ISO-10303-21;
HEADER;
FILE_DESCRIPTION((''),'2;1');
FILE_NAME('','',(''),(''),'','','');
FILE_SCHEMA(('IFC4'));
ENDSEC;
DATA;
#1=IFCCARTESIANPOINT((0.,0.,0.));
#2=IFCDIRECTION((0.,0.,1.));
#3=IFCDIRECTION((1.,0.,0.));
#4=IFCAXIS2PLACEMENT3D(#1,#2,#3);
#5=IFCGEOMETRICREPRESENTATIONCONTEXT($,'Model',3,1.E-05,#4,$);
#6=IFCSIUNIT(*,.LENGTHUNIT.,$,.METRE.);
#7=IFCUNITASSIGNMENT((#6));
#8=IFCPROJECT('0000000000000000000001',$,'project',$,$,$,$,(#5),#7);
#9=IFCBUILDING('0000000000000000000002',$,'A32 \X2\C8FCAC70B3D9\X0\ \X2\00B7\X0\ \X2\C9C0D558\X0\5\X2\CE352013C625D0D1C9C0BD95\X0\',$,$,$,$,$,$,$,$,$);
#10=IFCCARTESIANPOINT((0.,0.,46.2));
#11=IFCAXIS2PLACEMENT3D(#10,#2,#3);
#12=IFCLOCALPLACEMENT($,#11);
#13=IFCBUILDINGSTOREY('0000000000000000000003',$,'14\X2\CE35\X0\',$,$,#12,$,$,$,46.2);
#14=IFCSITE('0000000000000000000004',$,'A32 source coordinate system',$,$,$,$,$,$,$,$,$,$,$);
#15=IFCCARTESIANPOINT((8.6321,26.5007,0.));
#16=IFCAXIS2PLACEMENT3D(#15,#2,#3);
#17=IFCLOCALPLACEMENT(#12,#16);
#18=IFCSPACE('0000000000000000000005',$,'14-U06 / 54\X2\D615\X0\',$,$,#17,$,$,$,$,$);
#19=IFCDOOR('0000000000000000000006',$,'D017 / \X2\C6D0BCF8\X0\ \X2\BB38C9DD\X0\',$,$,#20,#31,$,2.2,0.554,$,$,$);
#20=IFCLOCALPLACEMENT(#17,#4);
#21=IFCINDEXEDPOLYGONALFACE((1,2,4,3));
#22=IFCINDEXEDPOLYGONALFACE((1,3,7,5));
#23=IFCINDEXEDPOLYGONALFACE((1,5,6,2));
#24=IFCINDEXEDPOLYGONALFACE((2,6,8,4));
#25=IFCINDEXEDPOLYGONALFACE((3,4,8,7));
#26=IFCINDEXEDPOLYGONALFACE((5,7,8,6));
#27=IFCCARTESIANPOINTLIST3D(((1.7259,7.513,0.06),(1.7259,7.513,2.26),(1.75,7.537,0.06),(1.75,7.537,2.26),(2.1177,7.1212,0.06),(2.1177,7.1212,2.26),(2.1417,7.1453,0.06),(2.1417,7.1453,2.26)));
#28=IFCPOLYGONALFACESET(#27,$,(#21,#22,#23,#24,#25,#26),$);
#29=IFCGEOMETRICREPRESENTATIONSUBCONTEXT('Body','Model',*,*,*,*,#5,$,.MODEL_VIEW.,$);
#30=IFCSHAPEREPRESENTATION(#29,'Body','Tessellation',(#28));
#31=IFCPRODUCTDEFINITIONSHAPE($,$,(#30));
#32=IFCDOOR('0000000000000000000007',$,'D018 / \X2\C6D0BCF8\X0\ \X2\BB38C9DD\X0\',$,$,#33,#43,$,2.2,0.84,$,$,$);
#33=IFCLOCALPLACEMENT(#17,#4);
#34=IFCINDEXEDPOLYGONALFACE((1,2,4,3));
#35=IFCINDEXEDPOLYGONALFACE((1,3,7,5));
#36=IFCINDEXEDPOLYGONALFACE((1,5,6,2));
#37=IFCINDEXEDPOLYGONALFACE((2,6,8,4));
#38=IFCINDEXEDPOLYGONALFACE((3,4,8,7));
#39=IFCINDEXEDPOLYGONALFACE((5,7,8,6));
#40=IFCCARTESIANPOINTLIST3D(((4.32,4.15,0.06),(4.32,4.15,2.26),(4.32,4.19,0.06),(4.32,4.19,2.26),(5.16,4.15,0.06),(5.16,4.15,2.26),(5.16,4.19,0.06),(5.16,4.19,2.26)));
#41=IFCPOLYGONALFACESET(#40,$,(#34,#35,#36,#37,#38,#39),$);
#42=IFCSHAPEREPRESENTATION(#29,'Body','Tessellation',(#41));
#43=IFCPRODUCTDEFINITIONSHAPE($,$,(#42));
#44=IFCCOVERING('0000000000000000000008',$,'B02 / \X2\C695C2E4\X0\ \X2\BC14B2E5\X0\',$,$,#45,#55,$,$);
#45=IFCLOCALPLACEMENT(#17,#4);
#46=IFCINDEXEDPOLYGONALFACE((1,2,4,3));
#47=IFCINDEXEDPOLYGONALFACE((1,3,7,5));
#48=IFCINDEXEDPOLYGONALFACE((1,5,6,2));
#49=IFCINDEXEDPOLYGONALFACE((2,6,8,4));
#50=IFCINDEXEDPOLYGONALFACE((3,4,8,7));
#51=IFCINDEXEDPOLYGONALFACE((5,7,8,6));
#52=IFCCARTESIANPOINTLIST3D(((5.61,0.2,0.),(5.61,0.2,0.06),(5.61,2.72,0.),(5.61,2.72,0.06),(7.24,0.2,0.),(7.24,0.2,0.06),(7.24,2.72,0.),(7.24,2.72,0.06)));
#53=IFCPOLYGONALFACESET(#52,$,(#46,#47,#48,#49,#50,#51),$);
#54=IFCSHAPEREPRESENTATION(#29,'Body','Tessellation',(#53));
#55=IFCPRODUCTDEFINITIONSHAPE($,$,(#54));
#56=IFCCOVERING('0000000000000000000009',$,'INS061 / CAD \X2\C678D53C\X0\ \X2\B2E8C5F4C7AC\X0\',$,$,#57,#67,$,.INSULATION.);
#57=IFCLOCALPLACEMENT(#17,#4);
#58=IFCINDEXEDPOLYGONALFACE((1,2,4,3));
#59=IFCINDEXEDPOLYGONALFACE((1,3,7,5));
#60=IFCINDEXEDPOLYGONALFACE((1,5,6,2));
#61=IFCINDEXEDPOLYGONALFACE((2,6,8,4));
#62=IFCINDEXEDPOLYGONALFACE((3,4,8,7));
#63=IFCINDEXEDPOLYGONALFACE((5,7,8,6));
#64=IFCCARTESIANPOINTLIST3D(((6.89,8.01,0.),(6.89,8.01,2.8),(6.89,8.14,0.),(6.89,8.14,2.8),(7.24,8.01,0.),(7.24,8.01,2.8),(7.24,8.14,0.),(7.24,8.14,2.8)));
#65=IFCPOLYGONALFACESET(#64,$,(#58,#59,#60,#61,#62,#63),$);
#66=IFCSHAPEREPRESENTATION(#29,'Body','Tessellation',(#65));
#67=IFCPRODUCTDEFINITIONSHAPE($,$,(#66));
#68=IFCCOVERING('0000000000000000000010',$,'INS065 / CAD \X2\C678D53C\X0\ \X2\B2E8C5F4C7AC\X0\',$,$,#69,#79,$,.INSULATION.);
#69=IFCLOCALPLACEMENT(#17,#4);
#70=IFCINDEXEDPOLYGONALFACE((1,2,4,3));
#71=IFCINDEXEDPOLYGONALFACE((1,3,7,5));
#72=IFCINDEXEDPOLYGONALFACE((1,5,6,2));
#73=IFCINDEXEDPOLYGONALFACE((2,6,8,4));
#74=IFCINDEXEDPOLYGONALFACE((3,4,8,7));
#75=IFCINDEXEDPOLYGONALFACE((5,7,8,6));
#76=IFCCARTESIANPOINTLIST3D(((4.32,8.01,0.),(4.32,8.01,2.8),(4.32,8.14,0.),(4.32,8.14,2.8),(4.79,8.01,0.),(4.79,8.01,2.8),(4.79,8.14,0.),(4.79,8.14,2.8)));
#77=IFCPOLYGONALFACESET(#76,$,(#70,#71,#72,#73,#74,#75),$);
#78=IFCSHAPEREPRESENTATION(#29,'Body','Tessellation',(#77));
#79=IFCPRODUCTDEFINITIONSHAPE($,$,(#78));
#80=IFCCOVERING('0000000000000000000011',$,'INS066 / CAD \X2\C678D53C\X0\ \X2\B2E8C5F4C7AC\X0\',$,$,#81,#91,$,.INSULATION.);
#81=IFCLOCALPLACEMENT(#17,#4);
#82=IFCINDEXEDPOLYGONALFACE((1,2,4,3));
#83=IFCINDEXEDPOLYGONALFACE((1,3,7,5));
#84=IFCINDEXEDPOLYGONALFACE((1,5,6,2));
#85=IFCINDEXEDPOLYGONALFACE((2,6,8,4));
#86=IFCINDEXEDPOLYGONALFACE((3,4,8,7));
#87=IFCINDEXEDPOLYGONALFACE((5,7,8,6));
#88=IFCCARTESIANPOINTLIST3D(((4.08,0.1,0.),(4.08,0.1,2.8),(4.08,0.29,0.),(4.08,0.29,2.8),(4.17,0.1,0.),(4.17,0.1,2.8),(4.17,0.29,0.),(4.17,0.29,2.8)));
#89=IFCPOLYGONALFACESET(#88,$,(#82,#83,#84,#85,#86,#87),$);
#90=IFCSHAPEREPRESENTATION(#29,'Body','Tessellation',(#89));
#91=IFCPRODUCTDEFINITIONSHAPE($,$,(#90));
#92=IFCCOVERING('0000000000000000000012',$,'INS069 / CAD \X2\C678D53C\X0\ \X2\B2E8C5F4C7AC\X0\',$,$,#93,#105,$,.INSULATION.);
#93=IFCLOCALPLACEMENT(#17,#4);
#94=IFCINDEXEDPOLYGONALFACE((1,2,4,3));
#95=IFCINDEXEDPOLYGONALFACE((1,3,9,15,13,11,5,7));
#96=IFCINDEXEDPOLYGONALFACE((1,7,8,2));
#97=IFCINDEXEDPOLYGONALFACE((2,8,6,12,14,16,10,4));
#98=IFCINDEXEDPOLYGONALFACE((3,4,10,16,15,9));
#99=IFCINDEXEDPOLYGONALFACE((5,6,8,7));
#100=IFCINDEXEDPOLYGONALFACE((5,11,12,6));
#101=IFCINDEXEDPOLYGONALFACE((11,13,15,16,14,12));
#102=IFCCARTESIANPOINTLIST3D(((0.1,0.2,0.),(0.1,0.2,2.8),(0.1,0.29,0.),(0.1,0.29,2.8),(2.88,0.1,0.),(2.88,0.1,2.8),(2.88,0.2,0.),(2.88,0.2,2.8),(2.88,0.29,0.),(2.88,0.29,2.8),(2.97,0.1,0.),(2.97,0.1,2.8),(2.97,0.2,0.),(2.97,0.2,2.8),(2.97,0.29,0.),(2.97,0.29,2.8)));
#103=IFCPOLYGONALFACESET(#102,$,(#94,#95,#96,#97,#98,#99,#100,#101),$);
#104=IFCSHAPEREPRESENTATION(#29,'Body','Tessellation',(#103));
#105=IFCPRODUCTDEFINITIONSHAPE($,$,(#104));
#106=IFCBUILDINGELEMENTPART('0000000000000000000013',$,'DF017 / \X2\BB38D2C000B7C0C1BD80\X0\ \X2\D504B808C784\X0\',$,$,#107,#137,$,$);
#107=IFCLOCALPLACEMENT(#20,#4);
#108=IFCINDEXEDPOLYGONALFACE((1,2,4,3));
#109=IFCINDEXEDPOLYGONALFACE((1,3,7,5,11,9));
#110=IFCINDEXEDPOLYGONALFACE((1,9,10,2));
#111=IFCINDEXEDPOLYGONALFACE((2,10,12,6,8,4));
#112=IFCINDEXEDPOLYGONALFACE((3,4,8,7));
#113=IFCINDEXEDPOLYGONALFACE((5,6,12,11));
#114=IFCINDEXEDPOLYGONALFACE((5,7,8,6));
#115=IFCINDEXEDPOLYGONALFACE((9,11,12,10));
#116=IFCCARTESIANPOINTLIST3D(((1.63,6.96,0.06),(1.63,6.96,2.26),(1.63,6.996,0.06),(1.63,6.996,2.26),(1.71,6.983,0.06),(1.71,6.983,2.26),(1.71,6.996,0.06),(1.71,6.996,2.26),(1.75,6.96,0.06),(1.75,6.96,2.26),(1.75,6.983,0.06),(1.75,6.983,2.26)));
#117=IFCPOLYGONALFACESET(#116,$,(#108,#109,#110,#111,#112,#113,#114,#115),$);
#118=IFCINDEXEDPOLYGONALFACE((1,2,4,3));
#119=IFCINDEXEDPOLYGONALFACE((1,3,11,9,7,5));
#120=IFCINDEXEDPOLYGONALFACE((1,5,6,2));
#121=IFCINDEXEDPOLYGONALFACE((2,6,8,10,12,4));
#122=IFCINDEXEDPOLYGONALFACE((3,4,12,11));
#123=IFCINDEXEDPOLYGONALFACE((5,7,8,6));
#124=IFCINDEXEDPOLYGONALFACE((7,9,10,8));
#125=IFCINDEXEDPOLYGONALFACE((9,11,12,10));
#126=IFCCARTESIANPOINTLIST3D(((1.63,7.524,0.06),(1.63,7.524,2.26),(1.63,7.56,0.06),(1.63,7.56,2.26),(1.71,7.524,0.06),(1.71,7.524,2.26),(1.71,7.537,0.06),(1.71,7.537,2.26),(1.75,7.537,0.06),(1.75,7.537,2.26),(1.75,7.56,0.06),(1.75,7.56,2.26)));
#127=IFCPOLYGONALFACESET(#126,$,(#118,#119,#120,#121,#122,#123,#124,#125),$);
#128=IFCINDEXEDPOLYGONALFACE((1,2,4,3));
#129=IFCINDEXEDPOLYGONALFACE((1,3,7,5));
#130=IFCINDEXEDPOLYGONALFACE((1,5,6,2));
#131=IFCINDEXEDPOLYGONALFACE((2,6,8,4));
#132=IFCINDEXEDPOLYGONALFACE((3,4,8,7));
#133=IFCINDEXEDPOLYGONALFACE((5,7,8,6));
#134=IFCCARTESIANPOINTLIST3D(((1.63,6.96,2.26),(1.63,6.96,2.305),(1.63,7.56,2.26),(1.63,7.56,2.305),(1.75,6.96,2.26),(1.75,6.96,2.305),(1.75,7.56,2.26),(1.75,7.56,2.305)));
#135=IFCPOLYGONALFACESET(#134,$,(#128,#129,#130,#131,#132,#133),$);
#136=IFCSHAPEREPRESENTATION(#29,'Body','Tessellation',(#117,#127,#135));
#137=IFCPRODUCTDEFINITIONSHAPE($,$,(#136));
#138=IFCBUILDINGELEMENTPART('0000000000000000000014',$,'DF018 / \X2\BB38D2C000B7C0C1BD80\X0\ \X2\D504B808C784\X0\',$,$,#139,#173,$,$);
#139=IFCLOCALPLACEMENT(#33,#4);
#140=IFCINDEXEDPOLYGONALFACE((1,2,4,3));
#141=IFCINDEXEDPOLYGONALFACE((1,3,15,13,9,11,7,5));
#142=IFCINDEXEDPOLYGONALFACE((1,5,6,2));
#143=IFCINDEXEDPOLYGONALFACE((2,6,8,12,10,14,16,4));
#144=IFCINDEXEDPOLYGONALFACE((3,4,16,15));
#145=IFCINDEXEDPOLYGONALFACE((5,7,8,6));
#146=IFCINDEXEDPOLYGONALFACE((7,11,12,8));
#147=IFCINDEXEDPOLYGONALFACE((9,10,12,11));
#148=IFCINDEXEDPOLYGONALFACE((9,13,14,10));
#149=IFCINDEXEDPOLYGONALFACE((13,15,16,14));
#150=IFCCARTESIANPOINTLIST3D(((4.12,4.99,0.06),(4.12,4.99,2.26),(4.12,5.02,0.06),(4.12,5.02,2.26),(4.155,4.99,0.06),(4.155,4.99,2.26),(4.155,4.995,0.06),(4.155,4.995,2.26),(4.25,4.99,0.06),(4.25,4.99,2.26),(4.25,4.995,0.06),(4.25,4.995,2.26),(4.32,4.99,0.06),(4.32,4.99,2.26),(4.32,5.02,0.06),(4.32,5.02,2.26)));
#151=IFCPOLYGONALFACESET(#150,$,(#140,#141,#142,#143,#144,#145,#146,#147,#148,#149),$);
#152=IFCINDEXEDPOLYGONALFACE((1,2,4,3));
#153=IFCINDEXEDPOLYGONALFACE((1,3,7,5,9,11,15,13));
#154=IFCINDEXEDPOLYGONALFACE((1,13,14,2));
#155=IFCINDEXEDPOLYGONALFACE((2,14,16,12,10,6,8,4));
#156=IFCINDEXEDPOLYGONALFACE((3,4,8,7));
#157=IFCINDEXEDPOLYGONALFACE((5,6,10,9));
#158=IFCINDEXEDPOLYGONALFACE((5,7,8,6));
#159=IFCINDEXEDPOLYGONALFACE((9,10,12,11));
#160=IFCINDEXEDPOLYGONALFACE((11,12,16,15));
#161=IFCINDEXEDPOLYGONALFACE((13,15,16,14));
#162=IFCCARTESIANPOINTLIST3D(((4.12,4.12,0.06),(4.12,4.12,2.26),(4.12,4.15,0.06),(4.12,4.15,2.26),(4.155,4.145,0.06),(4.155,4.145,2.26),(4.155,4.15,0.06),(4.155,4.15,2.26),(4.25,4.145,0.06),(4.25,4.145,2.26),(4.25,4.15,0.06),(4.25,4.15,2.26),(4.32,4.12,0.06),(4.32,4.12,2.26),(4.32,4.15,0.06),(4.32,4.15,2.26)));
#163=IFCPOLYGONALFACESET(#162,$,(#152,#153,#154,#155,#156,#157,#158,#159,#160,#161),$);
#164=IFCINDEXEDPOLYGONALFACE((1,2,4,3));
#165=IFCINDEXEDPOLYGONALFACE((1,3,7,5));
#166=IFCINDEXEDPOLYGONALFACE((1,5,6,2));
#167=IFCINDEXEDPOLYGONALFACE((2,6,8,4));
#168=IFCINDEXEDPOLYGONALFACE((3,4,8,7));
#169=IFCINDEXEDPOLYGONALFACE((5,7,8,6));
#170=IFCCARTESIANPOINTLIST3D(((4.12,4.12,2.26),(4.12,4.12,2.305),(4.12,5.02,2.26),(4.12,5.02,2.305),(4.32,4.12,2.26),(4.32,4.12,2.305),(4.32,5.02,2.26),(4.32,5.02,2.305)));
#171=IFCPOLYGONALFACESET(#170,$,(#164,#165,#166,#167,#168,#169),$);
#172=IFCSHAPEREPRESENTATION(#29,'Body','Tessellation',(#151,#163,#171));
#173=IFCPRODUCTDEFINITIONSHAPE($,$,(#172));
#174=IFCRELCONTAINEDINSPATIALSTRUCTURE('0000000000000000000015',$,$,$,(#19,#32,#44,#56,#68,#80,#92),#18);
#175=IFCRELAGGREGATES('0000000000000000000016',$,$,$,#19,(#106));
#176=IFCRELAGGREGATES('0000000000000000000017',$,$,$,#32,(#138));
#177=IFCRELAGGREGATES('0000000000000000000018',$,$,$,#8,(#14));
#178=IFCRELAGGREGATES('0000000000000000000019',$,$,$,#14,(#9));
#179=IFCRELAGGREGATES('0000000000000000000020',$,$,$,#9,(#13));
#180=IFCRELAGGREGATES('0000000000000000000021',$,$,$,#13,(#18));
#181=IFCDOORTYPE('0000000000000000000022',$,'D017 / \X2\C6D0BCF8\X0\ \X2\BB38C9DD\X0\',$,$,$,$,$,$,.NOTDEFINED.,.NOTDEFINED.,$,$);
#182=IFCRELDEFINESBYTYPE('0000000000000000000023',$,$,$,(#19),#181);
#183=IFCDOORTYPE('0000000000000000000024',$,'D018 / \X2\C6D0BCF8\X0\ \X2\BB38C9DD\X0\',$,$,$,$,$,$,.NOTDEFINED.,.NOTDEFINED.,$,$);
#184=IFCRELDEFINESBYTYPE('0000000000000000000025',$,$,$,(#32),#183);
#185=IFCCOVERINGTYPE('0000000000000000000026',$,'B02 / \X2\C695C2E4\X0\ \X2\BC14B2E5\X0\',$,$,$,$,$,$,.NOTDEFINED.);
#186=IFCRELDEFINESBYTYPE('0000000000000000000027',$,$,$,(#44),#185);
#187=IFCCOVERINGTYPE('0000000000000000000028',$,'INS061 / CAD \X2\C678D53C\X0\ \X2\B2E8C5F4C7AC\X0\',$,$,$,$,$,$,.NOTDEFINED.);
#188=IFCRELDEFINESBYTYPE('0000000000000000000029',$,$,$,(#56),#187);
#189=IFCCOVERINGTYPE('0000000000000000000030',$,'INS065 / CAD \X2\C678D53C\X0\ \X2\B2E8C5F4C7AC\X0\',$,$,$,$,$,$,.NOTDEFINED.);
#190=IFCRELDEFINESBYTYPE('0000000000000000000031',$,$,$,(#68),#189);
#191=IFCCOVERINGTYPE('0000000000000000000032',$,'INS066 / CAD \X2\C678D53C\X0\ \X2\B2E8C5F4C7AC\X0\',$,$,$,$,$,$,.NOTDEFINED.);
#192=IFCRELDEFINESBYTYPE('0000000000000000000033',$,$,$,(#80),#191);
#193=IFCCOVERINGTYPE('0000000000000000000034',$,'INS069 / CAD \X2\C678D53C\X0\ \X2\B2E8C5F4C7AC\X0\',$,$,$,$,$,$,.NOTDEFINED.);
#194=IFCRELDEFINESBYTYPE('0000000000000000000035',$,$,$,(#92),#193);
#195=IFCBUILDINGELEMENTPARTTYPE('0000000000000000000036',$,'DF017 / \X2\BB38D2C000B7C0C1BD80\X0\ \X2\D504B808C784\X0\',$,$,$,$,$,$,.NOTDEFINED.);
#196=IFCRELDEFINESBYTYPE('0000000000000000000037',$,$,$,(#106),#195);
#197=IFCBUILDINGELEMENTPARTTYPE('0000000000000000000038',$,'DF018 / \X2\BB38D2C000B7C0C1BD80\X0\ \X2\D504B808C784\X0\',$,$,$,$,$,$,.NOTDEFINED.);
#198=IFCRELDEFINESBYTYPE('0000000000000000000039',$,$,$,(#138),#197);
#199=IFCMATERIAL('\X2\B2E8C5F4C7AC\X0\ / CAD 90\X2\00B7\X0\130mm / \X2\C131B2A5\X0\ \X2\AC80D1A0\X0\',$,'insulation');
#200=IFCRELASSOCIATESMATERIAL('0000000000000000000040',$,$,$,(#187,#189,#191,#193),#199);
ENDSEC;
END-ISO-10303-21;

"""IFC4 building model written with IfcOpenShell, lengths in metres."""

from ifc_helpers import new_model, si_unit, frame, origin, origin_with_axes, place, context, subcontext, project, spatial, polyline, outline, extrude, source, transform, mapped, material, type_object, type_shapes, element, aggregate, save


model = new_model("IFC4")

# Units and contexts
model_context = context("Model", 3, precision=1e-05, world=origin_with_axes())
body_context = subcontext(model_context, "Body", "Model", "MODEL_VIEW")
ifc_project = project(units=[si_unit("LENGTHUNIT", "METRE")], contexts=[model_context])

# Site, building, storey, space
storey_placement = place(None, frame((0.0, 0.0, 46.2), z_axis=(0.0, 0.0, 1.0), x_axis=(1.0, 0.0, 0.0)))
space_1_placement = place(storey_placement, frame((8.6321, 26.5007, 0.0), z_axis=(0.0, 0.0, 1.0), x_axis=(1.0, 0.0, 0.0)))
site = spatial("IfcSite", under=ifc_project, Name="A32 source coordinate system")
building = spatial("IfcBuilding", under=site, Name="A32 주거동 · 지하5층–옥탑지붕")
storey = spatial("IfcBuildingStorey", under=building, at=storey_placement, Name="14층", Elevation=46.2)
space_1 = spatial("IfcSpace", under=storey, at=space_1_placement, Name="14-U06 / 54형")

# Doors
door_type_1 = type_object("IfcDoorType", Name="D017 / 원본 문짝", OperationType="NOTDEFINED", PredefinedType="NOTDEFINED")
shared_shape_1 = source(origin(), body_context, "Body", "SweptSolid", [
    extrude(outline(polyline([(1.75, 7.537), (2.1417, 7.1453), (2.1177, 7.1212), (1.7259, 7.513), (1.75, 7.537)])), frame((0.0, 0.0, 0.06)), (0.0, 0.0, 1.0), 2.2),
])
type_shapes(door_type_1, [shared_shape_1])
door_1_placement = place(space_1_placement, origin_with_axes())
door_1 = element("IfcDoor", 1, at=door_1_placement, inside=space_1, type_object=door_type_1, Name="D017 / 원본 문짝", OverallHeight=2.2, OverallWidth=0.554, context=body_context, shape_type="MappedRepresentation", body=[
    mapped(shared_shape_1, transform((0.0, 0.0, 0.0), scale=1.0)),
])
door_type_2 = type_object("IfcDoorType", Name="D018 / 원본 문짝", OperationType="NOTDEFINED", PredefinedType="NOTDEFINED")
shared_shape_2 = source(origin(), body_context, "Body", "SweptSolid", [
    extrude(outline(polyline([(5.16, 4.19), (5.16, 4.15), (4.32, 4.15), (4.32, 4.19), (5.16, 4.19)])), frame((0.0, 0.0, 0.06)), (0.0, 0.0, 1.0), 2.2),
])
type_shapes(door_type_2, [shared_shape_2])
door_2_placement = place(space_1_placement, origin_with_axes())
door_2 = element("IfcDoor", 2, at=door_2_placement, inside=space_1, type_object=door_type_2, Name="D018 / 원본 문짝", OverallHeight=2.2, OverallWidth=0.84, context=body_context, shape_type="MappedRepresentation", body=[
    mapped(shared_shape_2, transform((0.0, 0.0, 0.0), scale=1.0)),
])

# Coverings
covering_type_1 = type_object("IfcCoveringType", Name="B02 / 욕실 바닥", PredefinedType="NOTDEFINED")
shared_shape_3 = source(origin(), body_context, "Body", "SweptSolid", [
    extrude(outline(polyline([(5.61, 2.72), (7.24, 2.72), (7.24, 0.2), (5.61, 0.2), (5.61, 2.72)])), origin(), (0.0, 0.0, 1.0), 0.06),
])
type_shapes(covering_type_1, [shared_shape_3])
covering_1_placement = place(space_1_placement, origin_with_axes())
element("IfcCovering", 3, at=covering_1_placement, inside=space_1, type_object=covering_type_1, Name="B02 / 욕실 바닥", context=body_context, shape_type="MappedRepresentation", body=[
    mapped(shared_shape_3, transform((0.0, 0.0, 0.0), scale=1.0)),
])
ifc_material = material(Name="단열재 / CAD 90·130mm / 성능 검토", Category="insulation")
covering_type_2 = type_object("IfcCoveringType", Name="INS061 / CAD 외피 단열재", PredefinedType="NOTDEFINED", material=ifc_material)
shared_shape_4 = source(origin(), body_context, "Body", "SweptSolid", [
    extrude(outline(polyline([(6.89, 8.01), (6.89, 8.14), (7.24, 8.14), (7.24, 8.01), (6.89, 8.01)])), origin(), (0.0, 0.0, 1.0), 2.8),
])
type_shapes(covering_type_2, [shared_shape_4])
covering_2_placement = place(space_1_placement, origin_with_axes())
element("IfcCovering", 4, at=covering_2_placement, inside=space_1, type_object=covering_type_2, Name="INS061 / CAD 외피 단열재", PredefinedType="INSULATION", context=body_context, shape_type="MappedRepresentation", body=[
    mapped(shared_shape_4, transform((0.0, 0.0, 0.0), scale=1.0)),
])
covering_type_3 = type_object("IfcCoveringType", Name="INS065 / CAD 외피 단열재", PredefinedType="NOTDEFINED", material=ifc_material)
shared_shape_5 = source(origin(), body_context, "Body", "SweptSolid", [
    extrude(outline(polyline([(4.32, 8.01), (4.32, 8.14), (4.79, 8.14), (4.79, 8.01), (4.32, 8.01)])), origin(), (0.0, 0.0, 1.0), 2.8),
])
type_shapes(covering_type_3, [shared_shape_5])
covering_3_placement = place(space_1_placement, origin_with_axes())
element("IfcCovering", 5, at=covering_3_placement, inside=space_1, type_object=covering_type_3, Name="INS065 / CAD 외피 단열재", PredefinedType="INSULATION", context=body_context, shape_type="MappedRepresentation", body=[
    mapped(shared_shape_5, transform((0.0, 0.0, 0.0), scale=1.0)),
])
covering_type_4 = type_object("IfcCoveringType", Name="INS066 / CAD 외피 단열재", PredefinedType="NOTDEFINED", material=ifc_material)
shared_shape_6 = source(origin(), body_context, "Body", "SweptSolid", [
    extrude(outline(polyline([(4.08, 0.29), (4.17, 0.29), (4.17, 0.1), (4.08, 0.1), (4.08, 0.29)])), origin(), (0.0, 0.0, 1.0), 2.8),
])
type_shapes(covering_type_4, [shared_shape_6])
covering_4_placement = place(space_1_placement, origin_with_axes())
element("IfcCovering", 6, at=covering_4_placement, inside=space_1, type_object=covering_type_4, Name="INS066 / CAD 외피 단열재", PredefinedType="INSULATION", context=body_context, shape_type="MappedRepresentation", body=[
    mapped(shared_shape_6, transform((0.0, 0.0, 0.0), scale=1.0)),
])
covering_type_5 = type_object("IfcCoveringType", Name="INS069 / CAD 외피 단열재", PredefinedType="NOTDEFINED", material=ifc_material)
shared_shape_7 = source(origin(), body_context, "Body", "SweptSolid", [
    extrude(outline(polyline([(2.97, 0.1), (2.88, 0.1), (2.88, 0.2), (0.1, 0.2), (0.1, 0.29), (2.88, 0.29), (2.97, 0.29), (2.97, 0.2), (2.97, 0.1)])), origin(), (0.0, 0.0, 1.0), 2.8),
])
type_shapes(covering_type_5, [shared_shape_7])
covering_5_placement = place(space_1_placement, origin_with_axes())
element("IfcCovering", 7, at=covering_5_placement, inside=space_1, type_object=covering_type_5, Name="INS069 / CAD 외피 단열재", PredefinedType="INSULATION", context=body_context, shape_type="MappedRepresentation", body=[
    mapped(shared_shape_7, transform((0.0, 0.0, 0.0), scale=1.0)),
])

# Building element parts
building_element_part_type_1 = type_object("IfcBuildingElementPartType", Name="DF017 / 문틀·상부 프레임", PredefinedType="NOTDEFINED")
shared_shape_8 = source(origin(), body_context, "Body", "SweptSolid", [
    extrude(outline(polyline([(1.63, 6.996), (1.71, 6.996), (1.71, 6.983), (1.75, 6.983), (1.75, 6.96), (1.63, 6.96), (1.63, 6.996)])), frame((0.0, 0.0, 0.06)), (0.0, 0.0, 1.0), 2.2),
    extrude(outline(polyline([(1.75, 7.56), (1.75, 7.537), (1.71, 7.537), (1.71, 7.524), (1.63, 7.524), (1.63, 7.56), (1.75, 7.56)])), frame((0.0, 0.0, 0.06)), (0.0, 0.0, 1.0), 2.2),
    extrude(outline(polyline([(1.63, 6.96), (1.63, 7.56), (1.75, 7.56), (1.75, 6.96), (1.63, 6.96)])), frame((0.0, 0.0, 2.26)), (0.0, 0.0, 1.0), 0.045),
])
type_shapes(building_element_part_type_1, [shared_shape_8])
building_element_part_1_placement = place(door_1_placement, origin_with_axes())
building_element_part_1 = element("IfcBuildingElementPart", 8, at=building_element_part_1_placement, type_object=building_element_part_type_1, Name="DF017 / 문틀·상부 프레임", context=body_context, shape_type="MappedRepresentation", body=[
    mapped(shared_shape_8, transform((0.0, 0.0, 0.0), scale=1.0)),
])
aggregate(door_1, [building_element_part_1])
building_element_part_type_2 = type_object("IfcBuildingElementPartType", Name="DF018 / 문틀·상부 프레임", PredefinedType="NOTDEFINED")
shared_shape_9 = source(origin(), body_context, "Body", "SweptSolid", [
    extrude(outline(polyline([(4.32, 4.99), (4.25, 4.99), (4.25, 4.995), (4.155, 4.995), (4.155, 4.99), (4.12, 4.99), (4.12, 5.02), (4.32, 5.02), (4.32, 4.99)])), frame((0.0, 0.0, 0.06)), (0.0, 0.0, 1.0), 2.2),
    extrude(outline(polyline([(4.12, 4.12), (4.12, 4.15), (4.155, 4.15), (4.155, 4.145), (4.25, 4.145), (4.25, 4.15), (4.32, 4.15), (4.32, 4.12), (4.12, 4.12)])), frame((0.0, 0.0, 0.06)), (0.0, 0.0, 1.0), 2.2),
    extrude(outline(polyline([(4.12, 4.12), (4.12, 5.02), (4.32, 5.02), (4.32, 4.12), (4.12, 4.12)])), frame((0.0, 0.0, 2.26)), (0.0, 0.0, 1.0), 0.045),
])
type_shapes(building_element_part_type_2, [shared_shape_9])
building_element_part_2_placement = place(door_2_placement, origin_with_axes())
building_element_part_2 = element("IfcBuildingElementPart", 9, at=building_element_part_2_placement, type_object=building_element_part_type_2, Name="DF018 / 문틀·상부 프레임", context=body_context, shape_type="MappedRepresentation", body=[
    mapped(shared_shape_9, transform((0.0, 0.0, 0.0), scale=1.0)),
])
aggregate(door_2, [building_element_part_2])

save(model, "model.ifc")
